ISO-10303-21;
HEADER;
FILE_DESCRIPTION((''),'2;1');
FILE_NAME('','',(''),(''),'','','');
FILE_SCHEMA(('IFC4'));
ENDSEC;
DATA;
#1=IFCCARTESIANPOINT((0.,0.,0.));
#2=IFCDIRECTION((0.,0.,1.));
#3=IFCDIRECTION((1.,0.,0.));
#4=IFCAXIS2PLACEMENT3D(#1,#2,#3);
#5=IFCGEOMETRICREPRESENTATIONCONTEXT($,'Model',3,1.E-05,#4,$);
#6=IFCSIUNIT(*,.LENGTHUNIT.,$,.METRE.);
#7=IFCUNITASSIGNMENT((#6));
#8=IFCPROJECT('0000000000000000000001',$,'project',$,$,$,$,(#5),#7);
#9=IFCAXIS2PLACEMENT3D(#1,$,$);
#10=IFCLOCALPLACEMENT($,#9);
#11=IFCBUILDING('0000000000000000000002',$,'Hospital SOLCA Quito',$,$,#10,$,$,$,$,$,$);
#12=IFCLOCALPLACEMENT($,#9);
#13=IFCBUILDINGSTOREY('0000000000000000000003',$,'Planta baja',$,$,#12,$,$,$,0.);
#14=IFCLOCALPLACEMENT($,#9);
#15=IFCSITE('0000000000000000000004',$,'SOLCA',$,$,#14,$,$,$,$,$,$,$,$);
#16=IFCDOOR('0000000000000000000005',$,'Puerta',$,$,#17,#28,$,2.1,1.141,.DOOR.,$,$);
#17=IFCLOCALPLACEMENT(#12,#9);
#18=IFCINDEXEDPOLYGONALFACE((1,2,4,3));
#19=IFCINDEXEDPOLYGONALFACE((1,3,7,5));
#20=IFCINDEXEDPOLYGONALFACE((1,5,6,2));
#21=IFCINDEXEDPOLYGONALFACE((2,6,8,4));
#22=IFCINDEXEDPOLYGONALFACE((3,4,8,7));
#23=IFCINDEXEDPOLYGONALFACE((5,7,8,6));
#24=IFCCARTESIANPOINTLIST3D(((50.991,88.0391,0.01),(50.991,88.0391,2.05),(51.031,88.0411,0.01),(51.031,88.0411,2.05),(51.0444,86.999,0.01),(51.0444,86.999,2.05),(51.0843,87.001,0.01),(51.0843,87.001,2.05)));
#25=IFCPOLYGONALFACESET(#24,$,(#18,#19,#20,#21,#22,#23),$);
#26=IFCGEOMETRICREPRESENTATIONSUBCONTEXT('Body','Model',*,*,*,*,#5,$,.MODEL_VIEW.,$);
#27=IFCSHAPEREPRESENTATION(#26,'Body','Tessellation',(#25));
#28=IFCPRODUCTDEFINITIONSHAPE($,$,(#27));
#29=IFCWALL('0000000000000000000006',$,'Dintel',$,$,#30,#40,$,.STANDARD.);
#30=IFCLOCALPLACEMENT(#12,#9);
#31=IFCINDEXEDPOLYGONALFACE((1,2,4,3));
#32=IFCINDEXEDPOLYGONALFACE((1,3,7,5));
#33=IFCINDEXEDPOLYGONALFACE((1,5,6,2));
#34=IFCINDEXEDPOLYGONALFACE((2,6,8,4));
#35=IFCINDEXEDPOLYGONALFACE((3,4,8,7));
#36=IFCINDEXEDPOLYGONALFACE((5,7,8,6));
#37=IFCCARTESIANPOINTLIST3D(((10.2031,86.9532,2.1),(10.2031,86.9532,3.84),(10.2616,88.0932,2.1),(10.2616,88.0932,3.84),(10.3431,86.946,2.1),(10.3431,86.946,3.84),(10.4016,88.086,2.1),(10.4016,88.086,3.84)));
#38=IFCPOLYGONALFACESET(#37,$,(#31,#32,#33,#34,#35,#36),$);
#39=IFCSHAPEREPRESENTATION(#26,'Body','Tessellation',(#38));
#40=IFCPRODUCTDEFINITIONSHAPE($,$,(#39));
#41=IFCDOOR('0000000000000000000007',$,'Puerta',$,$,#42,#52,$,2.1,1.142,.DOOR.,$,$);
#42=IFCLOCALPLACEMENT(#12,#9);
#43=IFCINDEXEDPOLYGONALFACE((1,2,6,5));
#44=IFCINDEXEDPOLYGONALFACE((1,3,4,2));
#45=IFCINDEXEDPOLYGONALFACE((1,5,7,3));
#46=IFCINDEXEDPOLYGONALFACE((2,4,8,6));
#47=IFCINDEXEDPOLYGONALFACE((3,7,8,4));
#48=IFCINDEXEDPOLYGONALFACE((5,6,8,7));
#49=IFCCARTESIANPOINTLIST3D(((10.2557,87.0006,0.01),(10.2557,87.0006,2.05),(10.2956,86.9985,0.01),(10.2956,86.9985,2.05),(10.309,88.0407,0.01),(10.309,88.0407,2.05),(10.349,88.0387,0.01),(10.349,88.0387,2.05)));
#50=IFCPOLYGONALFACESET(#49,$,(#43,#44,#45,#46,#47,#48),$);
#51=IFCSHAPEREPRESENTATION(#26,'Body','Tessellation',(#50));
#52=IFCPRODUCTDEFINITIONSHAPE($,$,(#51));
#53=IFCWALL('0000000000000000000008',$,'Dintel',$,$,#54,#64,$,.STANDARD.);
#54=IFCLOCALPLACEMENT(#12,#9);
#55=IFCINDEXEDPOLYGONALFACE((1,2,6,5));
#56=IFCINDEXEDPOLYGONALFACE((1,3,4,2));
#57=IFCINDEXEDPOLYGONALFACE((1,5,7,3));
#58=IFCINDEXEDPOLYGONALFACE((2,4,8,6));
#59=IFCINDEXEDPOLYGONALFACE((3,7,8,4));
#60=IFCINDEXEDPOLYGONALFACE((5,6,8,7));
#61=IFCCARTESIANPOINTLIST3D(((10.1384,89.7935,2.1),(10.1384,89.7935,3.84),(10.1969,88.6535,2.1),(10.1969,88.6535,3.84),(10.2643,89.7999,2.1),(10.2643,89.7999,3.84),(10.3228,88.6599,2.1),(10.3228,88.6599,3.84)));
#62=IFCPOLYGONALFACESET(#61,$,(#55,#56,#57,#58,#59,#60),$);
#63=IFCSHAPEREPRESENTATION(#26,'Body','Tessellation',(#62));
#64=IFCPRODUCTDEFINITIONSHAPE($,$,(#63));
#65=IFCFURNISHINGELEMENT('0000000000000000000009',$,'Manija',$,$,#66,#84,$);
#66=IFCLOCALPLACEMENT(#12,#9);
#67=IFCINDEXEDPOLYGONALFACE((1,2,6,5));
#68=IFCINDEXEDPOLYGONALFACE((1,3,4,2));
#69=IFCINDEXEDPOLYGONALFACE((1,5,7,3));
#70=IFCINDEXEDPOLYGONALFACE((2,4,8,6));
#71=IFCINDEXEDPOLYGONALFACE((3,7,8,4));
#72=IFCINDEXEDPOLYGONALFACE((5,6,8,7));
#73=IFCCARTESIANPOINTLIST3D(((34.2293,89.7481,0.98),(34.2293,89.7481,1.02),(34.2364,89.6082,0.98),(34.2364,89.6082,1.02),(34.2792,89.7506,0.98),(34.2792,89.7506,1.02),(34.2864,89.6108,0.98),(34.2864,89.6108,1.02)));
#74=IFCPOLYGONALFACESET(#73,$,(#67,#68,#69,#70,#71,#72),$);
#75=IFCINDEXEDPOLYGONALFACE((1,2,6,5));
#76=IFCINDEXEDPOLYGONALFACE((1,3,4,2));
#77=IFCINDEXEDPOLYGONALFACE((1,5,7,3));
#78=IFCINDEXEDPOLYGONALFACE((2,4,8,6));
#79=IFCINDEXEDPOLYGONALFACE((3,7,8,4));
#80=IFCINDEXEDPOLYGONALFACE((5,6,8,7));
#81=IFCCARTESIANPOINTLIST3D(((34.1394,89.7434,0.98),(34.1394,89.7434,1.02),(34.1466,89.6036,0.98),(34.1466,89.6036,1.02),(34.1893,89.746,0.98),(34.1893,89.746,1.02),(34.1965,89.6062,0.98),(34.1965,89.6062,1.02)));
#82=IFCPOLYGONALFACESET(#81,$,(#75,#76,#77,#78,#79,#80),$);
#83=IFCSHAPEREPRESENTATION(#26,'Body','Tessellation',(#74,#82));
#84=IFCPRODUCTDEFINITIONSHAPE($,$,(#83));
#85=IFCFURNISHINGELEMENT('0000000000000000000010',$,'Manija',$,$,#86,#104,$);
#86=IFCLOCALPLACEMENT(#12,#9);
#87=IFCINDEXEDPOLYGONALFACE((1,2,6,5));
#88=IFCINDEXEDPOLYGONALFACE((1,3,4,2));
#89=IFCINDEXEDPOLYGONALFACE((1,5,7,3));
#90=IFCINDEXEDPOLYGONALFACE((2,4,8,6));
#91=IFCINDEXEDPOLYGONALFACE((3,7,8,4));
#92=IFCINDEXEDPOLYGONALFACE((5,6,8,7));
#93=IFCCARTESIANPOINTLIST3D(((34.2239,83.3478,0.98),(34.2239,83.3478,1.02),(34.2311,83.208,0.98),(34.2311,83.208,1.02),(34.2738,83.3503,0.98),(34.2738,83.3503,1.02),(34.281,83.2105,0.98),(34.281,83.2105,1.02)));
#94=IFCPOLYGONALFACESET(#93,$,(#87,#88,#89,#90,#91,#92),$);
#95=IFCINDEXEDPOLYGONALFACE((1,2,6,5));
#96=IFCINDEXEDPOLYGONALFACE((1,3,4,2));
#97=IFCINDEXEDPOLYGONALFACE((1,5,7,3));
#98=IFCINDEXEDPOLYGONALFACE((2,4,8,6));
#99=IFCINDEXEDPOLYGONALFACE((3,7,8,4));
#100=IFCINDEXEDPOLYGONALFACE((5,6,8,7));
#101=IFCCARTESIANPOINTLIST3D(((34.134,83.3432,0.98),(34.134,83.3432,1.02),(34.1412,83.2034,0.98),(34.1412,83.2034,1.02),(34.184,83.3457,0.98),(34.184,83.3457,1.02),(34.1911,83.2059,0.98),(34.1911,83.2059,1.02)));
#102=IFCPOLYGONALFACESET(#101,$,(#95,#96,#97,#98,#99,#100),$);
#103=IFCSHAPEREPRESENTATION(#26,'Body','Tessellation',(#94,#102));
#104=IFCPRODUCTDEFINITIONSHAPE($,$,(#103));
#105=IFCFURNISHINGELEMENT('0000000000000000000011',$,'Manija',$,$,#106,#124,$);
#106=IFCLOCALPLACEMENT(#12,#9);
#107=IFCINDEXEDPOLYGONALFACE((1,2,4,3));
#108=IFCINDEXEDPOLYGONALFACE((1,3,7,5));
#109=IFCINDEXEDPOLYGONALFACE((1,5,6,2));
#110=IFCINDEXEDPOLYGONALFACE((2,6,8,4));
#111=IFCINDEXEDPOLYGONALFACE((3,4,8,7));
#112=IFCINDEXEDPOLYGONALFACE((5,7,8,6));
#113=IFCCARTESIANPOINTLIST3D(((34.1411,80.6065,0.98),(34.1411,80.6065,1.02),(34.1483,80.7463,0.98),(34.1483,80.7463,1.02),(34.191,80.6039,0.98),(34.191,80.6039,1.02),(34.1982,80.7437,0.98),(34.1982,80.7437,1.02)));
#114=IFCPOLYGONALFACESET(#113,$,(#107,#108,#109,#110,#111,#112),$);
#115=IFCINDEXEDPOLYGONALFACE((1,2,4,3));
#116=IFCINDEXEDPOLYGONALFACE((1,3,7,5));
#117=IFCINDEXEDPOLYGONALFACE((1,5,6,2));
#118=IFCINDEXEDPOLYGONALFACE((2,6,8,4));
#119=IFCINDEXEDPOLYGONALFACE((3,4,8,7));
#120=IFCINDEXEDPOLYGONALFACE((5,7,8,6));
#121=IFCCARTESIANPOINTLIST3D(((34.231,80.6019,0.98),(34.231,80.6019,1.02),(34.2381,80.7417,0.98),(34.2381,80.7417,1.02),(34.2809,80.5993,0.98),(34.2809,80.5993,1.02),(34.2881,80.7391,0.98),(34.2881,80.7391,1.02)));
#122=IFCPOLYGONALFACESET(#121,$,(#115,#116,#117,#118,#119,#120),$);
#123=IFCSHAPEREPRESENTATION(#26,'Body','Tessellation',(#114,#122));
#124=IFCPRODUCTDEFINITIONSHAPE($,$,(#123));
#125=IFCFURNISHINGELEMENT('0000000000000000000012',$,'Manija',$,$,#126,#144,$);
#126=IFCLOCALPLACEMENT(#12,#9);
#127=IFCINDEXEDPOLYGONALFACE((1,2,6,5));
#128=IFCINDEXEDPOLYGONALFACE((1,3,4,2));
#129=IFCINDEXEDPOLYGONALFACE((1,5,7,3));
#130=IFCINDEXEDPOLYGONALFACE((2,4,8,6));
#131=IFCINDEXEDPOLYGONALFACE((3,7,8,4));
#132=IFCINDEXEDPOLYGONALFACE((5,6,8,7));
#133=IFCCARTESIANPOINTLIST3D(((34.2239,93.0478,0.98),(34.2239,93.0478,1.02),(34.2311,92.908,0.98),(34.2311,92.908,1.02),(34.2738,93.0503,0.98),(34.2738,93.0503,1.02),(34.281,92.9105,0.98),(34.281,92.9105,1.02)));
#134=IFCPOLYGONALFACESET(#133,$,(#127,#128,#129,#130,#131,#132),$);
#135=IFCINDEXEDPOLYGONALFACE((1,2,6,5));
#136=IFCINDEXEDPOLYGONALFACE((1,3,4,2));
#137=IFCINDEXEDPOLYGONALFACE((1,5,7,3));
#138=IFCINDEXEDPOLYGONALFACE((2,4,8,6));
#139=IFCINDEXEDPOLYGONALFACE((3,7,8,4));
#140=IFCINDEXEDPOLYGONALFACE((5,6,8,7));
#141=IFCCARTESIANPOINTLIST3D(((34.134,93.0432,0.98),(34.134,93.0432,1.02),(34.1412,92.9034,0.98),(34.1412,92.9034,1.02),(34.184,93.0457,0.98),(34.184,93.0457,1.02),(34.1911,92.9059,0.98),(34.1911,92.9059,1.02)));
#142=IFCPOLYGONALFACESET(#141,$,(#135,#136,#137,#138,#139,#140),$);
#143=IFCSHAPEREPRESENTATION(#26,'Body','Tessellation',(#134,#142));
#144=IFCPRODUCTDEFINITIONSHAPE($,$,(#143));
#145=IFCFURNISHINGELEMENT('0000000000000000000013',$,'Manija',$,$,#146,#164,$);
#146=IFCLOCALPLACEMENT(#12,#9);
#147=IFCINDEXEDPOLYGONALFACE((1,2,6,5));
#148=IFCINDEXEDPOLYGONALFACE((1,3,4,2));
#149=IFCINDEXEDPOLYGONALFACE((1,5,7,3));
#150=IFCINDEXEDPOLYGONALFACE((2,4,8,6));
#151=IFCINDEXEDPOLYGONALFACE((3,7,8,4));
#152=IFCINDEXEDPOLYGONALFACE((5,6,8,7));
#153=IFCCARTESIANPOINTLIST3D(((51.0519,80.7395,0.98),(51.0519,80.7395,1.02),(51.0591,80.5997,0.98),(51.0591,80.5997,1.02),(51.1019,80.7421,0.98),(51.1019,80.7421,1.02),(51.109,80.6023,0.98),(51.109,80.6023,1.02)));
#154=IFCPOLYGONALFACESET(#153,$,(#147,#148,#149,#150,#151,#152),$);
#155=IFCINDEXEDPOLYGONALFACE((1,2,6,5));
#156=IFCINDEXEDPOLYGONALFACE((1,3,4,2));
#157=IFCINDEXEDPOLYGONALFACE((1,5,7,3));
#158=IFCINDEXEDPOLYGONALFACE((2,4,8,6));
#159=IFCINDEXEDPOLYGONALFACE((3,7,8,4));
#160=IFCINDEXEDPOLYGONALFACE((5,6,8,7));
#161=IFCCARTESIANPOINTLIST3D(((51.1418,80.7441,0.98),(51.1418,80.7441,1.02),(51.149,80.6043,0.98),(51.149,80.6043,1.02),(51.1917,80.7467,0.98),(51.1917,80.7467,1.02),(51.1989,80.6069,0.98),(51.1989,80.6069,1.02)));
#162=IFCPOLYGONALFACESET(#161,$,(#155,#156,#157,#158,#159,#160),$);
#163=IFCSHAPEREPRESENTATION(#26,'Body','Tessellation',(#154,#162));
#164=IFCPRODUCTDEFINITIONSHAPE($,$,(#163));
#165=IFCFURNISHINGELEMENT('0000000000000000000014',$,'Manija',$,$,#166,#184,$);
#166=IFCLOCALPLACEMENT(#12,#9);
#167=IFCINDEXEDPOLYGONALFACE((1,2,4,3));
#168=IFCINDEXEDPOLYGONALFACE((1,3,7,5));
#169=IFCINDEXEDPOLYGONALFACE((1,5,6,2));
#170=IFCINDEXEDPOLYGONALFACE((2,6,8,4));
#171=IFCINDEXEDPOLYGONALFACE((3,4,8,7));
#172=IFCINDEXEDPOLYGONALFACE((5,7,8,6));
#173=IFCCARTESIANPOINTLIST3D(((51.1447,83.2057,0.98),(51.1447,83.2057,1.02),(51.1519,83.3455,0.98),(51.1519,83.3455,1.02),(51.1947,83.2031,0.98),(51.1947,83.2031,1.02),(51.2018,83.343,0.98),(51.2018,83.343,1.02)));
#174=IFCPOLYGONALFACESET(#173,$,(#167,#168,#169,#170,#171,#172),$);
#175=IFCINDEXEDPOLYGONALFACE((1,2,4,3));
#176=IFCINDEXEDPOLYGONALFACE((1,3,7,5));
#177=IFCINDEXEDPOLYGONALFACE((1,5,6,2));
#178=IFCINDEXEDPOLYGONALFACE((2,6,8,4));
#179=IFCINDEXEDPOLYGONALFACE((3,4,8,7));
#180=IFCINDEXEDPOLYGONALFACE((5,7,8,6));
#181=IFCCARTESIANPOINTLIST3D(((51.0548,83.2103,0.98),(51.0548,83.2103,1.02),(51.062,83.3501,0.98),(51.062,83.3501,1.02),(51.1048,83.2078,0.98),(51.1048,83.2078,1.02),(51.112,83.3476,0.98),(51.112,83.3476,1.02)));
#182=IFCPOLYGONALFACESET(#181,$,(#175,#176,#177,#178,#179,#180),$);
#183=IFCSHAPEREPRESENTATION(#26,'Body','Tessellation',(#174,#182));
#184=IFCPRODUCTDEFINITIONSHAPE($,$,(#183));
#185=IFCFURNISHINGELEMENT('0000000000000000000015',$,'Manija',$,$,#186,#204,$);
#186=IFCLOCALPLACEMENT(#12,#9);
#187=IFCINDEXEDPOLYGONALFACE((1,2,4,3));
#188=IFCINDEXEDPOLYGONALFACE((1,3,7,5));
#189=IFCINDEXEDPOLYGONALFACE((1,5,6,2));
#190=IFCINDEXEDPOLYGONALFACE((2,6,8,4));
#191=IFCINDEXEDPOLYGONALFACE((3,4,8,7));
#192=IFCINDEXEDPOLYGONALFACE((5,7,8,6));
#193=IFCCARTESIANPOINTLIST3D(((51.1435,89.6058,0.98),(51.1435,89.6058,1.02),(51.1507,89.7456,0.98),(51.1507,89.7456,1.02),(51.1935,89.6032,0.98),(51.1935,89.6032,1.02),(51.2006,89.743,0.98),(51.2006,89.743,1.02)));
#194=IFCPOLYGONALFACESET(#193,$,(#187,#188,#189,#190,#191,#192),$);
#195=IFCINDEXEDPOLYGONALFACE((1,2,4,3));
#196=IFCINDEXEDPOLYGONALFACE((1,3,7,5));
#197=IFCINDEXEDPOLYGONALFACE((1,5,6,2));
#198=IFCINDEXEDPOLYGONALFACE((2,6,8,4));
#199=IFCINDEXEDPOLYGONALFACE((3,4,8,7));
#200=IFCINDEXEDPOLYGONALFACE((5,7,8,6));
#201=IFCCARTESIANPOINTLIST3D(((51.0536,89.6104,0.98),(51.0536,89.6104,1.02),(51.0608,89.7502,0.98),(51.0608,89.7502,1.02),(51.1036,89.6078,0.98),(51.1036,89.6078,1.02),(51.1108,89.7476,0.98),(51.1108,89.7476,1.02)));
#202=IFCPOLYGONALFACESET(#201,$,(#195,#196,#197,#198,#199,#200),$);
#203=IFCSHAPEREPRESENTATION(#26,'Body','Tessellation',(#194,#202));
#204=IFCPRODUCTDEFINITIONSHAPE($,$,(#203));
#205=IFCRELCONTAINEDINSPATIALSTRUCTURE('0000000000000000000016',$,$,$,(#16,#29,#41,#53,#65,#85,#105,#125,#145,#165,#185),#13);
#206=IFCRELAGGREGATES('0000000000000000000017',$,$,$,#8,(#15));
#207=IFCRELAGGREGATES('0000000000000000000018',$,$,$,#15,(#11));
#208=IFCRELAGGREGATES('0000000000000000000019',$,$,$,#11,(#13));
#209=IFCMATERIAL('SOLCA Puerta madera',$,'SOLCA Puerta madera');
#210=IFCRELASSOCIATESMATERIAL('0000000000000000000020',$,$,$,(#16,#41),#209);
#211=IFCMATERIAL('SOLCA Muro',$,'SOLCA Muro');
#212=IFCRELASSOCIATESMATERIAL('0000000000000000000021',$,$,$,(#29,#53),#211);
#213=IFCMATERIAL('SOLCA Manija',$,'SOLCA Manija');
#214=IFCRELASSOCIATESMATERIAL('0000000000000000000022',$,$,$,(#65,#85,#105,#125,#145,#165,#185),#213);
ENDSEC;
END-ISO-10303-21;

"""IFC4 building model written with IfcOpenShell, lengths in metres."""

from ifc_helpers import new_model, si_unit, frame, origin, origin_with_axes, place, context, subcontext, project, spatial, polyline, outline, extrude, material, element, save


model = new_model("IFC4")

# Units and contexts
model_context = context("Model", 3, precision=1e-05, world=origin_with_axes())
body_context = subcontext(model_context, "Body", "Model", "MODEL_VIEW")
ifc_project = project(units=[si_unit("LENGTHUNIT", "METRE")], contexts=[model_context])

# Site, building, storey
site_placement = place(None, origin())
site = spatial("IfcSite", under=ifc_project, at=site_placement, Name="SOLCA")
building_placement = place(None, origin())
building = spatial("IfcBuilding", under=site, at=building_placement, Name="Hospital SOLCA Quito")
storey_placement = place(None, origin())
storey = spatial("IfcBuildingStorey", under=building, at=storey_placement, Name="Planta baja", Elevation=0.0)

# Shared definitions
ifc_material_1 = material(Name="SOLCA Muro", Category="SOLCA Muro")

# Shared definitions
ifc_material_2 = material(Name="SOLCA Puerta madera", Category="SOLCA Puerta madera")

# Door
door_1_placement = place(storey_placement, origin_with_axes())
element("IfcDoor", 1, at=door_1_placement, inside=storey, material=ifc_material_2, Name="Puerta", OverallHeight=2.1, OverallWidth=1.141, PredefinedType="DOOR", context=body_context, shape_type="SweptSolid", body=[
    extrude(outline(polyline([(50.991, 88.0391), (51.0444, 86.999), (51.0843, 87.001), (51.031, 88.0411), (50.991, 88.0391)])), frame((0.0, 0.0, 0.01), z_axis=(0.0, 0.0, 1.0), x_axis=(1.0, 0.0, 0.0)), (0.0, 0.0, 1.0), 2.04),
])

# Wall
wall_1_placement = place(storey_placement, origin_with_axes())
element("IfcWall", 2, at=wall_1_placement, inside=storey, material=ifc_material_1, Name="Dintel", PredefinedType="STANDARD", context=body_context, shape_type="SweptSolid", body=[
    extrude(outline(polyline([(10.2616, 88.0932), (10.2031, 86.9532), (10.3431, 86.946), (10.4016, 88.086), (10.2616, 88.0932)])), frame((0.0, 0.0, 2.1), z_axis=(0.0, 0.0, 1.0), x_axis=(1.0, 0.0, 0.0)), (0.0, 0.0, 1.0), 1.74),
])

# Door
door_2_placement = place(storey_placement, origin_with_axes())
element("IfcDoor", 3, at=door_2_placement, inside=storey, material=ifc_material_2, Name="Puerta", OverallHeight=2.1, OverallWidth=1.142, PredefinedType="DOOR", context=body_context, shape_type="SweptSolid", body=[
    extrude(outline(polyline([(10.309, 88.0407), (10.2557, 87.0006), (10.2956, 86.9985), (10.349, 88.0387), (10.309, 88.0407)])), frame((0.0, 0.0, 0.01), z_axis=(0.0, 0.0, 1.0), x_axis=(1.0, 0.0, 0.0)), (0.0, 0.0, 1.0), 2.04),
])

# Wall
wall_2_placement = place(storey_placement, origin_with_axes())
element("IfcWall", 4, at=wall_2_placement, inside=storey, material=ifc_material_1, Name="Dintel", PredefinedType="STANDARD", context=body_context, shape_type="SweptSolid", body=[
    extrude(outline(polyline([(10.3228, 88.6599), (10.2643, 89.7999), (10.1384, 89.7935), (10.1969, 88.6535), (10.3228, 88.6599)])), frame((0.0, 0.0, 2.1), z_axis=(0.0, 0.0, 1.0), x_axis=(1.0, 0.0, 0.0)), (0.0, 0.0, 1.0), 1.74),
])

# Furnishing elements
ifc_material_3 = material(Name="SOLCA Manija", Category="SOLCA Manija")
furnishing_1_placement = place(storey_placement, origin_with_axes())
element("IfcFurnishingElement", 5, at=furnishing_1_placement, inside=storey, material=ifc_material_3, Name="Manija", context=body_context, shape_type="SweptSolid", body=[
    extrude(outline(polyline([(34.2864, 89.6108), (34.2792, 89.7506), (34.2293, 89.7481), (34.2364, 89.6082), (34.2864, 89.6108)])), frame((0.0, 0.0, 0.98), z_axis=(0.0, 0.0, 1.0), x_axis=(1.0, 0.0, 0.0)), (0.0, 0.0, 1.0), 0.04),
    extrude(outline(polyline([(34.1965, 89.6062), (34.1893, 89.746), (34.1394, 89.7434), (34.1466, 89.6036), (34.1965, 89.6062)])), frame((0.0, 0.0, 0.98), z_axis=(0.0, 0.0, 1.0), x_axis=(1.0, 0.0, 0.0)), (0.0, 0.0, 1.0), 0.04),
])
furnishing_2_placement = place(storey_placement, origin_with_axes())
element("IfcFurnishingElement", 6, at=furnishing_2_placement, inside=storey, material=ifc_material_3, Name="Manija", context=body_context, shape_type="SweptSolid", body=[
    extrude(outline(polyline([(34.281, 83.2105), (34.2738, 83.3503), (34.2239, 83.3478), (34.2311, 83.208), (34.281, 83.2105)])), frame((0.0, 0.0, 0.98), z_axis=(0.0, 0.0, 1.0), x_axis=(1.0, 0.0, 0.0)), (0.0, 0.0, 1.0), 0.04),
    extrude(outline(polyline([(34.1911, 83.2059), (34.184, 83.3457), (34.134, 83.3432), (34.1412, 83.2034), (34.1911, 83.2059)])), frame((0.0, 0.0, 0.98), z_axis=(0.0, 0.0, 1.0), x_axis=(1.0, 0.0, 0.0)), (0.0, 0.0, 1.0), 0.04),
])
furnishing_3_placement = place(storey_placement, origin_with_axes())
element("IfcFurnishingElement", 7, at=furnishing_3_placement, inside=storey, material=ifc_material_3, Name="Manija", context=body_context, shape_type="SweptSolid", body=[
    extrude(outline(polyline([(34.1483, 80.7463), (34.1411, 80.6065), (34.191, 80.6039), (34.1982, 80.7437), (34.1483, 80.7463)])), frame((0.0, 0.0, 0.98), z_axis=(0.0, 0.0, 1.0), x_axis=(1.0, 0.0, 0.0)), (0.0, 0.0, 1.0), 0.04),
    extrude(outline(polyline([(34.2381, 80.7417), (34.231, 80.6019), (34.2809, 80.5993), (34.2881, 80.7391), (34.2381, 80.7417)])), frame((0.0, 0.0, 0.98), z_axis=(0.0, 0.0, 1.0), x_axis=(1.0, 0.0, 0.0)), (0.0, 0.0, 1.0), 0.04),
])
furnishing_4_placement = place(storey_placement, origin_with_axes())
element("IfcFurnishingElement", 8, at=furnishing_4_placement, inside=storey, material=ifc_material_3, Name="Manija", context=body_context, shape_type="SweptSolid", body=[
    extrude(outline(polyline([(34.281, 92.9105), (34.2738, 93.0503), (34.2239, 93.0478), (34.2311, 92.908), (34.281, 92.9105)])), frame((0.0, 0.0, 0.98), z_axis=(0.0, 0.0, 1.0), x_axis=(1.0, 0.0, 0.0)), (0.0, 0.0, 1.0), 0.04),
    extrude(outline(polyline([(34.1911, 92.9059), (34.184, 93.0457), (34.134, 93.0432), (34.1412, 92.9034), (34.1911, 92.9059)])), frame((0.0, 0.0, 0.98), z_axis=(0.0, 0.0, 1.0), x_axis=(1.0, 0.0, 0.0)), (0.0, 0.0, 1.0), 0.04),
])
furnishing_5_placement = place(storey_placement, origin_with_axes())
element("IfcFurnishingElement", 9, at=furnishing_5_placement, inside=storey, material=ifc_material_3, Name="Manija", context=body_context, shape_type="SweptSolid", body=[
    extrude(outline(polyline([(51.0519, 80.7395), (51.0591, 80.5997), (51.109, 80.6023), (51.1019, 80.7421), (51.0519, 80.7395)])), frame((0.0, 0.0, 0.98), z_axis=(0.0, 0.0, 1.0), x_axis=(1.0, 0.0, 0.0)), (0.0, 0.0, 1.0), 0.04),
    extrude(outline(polyline([(51.1418, 80.7441), (51.149, 80.6043), (51.1989, 80.6069), (51.1917, 80.7467), (51.1418, 80.7441)])), frame((0.0, 0.0, 0.98), z_axis=(0.0, 0.0, 1.0), x_axis=(1.0, 0.0, 0.0)), (0.0, 0.0, 1.0), 0.04),
])
furnishing_6_placement = place(storey_placement, origin_with_axes())
element("IfcFurnishingElement", 10, at=furnishing_6_placement, inside=storey, material=ifc_material_3, Name="Manija", context=body_context, shape_type="SweptSolid", body=[
    extrude(outline(polyline([(51.1947, 83.2031), (51.2018, 83.343), (51.1519, 83.3455), (51.1447, 83.2057), (51.1947, 83.2031)])), frame((0.0, 0.0, 0.98), z_axis=(0.0, 0.0, 1.0), x_axis=(1.0, 0.0, 0.0)), (0.0, 0.0, 1.0), 0.04),
    extrude(outline(polyline([(51.1048, 83.2078), (51.112, 83.3476), (51.062, 83.3501), (51.0548, 83.2103), (51.1048, 83.2078)])), frame((0.0, 0.0, 0.98), z_axis=(0.0, 0.0, 1.0), x_axis=(1.0, 0.0, 0.0)), (0.0, 0.0, 1.0), 0.04),
])
furnishing_7_placement = place(storey_placement, origin_with_axes())
element("IfcFurnishingElement", 11, at=furnishing_7_placement, inside=storey, material=ifc_material_3, Name="Manija", context=body_context, shape_type="SweptSolid", body=[
    extrude(outline(polyline([(51.1935, 89.6032), (51.2006, 89.743), (51.1507, 89.7456), (51.1435, 89.6058), (51.1935, 89.6032)])), frame((0.0, 0.0, 0.98), z_axis=(0.0, 0.0, 1.0), x_axis=(1.0, 0.0, 0.0)), (0.0, 0.0, 1.0), 0.04),
    extrude(outline(polyline([(51.1036, 89.6078), (51.1108, 89.7476), (51.0608, 89.7502), (51.0536, 89.6104), (51.1036, 89.6078)])), frame((0.0, 0.0, 0.98), z_axis=(0.0, 0.0, 1.0), x_axis=(1.0, 0.0, 0.0)), (0.0, 0.0, 1.0), 0.04),
])

save(model, "model.ifc")
